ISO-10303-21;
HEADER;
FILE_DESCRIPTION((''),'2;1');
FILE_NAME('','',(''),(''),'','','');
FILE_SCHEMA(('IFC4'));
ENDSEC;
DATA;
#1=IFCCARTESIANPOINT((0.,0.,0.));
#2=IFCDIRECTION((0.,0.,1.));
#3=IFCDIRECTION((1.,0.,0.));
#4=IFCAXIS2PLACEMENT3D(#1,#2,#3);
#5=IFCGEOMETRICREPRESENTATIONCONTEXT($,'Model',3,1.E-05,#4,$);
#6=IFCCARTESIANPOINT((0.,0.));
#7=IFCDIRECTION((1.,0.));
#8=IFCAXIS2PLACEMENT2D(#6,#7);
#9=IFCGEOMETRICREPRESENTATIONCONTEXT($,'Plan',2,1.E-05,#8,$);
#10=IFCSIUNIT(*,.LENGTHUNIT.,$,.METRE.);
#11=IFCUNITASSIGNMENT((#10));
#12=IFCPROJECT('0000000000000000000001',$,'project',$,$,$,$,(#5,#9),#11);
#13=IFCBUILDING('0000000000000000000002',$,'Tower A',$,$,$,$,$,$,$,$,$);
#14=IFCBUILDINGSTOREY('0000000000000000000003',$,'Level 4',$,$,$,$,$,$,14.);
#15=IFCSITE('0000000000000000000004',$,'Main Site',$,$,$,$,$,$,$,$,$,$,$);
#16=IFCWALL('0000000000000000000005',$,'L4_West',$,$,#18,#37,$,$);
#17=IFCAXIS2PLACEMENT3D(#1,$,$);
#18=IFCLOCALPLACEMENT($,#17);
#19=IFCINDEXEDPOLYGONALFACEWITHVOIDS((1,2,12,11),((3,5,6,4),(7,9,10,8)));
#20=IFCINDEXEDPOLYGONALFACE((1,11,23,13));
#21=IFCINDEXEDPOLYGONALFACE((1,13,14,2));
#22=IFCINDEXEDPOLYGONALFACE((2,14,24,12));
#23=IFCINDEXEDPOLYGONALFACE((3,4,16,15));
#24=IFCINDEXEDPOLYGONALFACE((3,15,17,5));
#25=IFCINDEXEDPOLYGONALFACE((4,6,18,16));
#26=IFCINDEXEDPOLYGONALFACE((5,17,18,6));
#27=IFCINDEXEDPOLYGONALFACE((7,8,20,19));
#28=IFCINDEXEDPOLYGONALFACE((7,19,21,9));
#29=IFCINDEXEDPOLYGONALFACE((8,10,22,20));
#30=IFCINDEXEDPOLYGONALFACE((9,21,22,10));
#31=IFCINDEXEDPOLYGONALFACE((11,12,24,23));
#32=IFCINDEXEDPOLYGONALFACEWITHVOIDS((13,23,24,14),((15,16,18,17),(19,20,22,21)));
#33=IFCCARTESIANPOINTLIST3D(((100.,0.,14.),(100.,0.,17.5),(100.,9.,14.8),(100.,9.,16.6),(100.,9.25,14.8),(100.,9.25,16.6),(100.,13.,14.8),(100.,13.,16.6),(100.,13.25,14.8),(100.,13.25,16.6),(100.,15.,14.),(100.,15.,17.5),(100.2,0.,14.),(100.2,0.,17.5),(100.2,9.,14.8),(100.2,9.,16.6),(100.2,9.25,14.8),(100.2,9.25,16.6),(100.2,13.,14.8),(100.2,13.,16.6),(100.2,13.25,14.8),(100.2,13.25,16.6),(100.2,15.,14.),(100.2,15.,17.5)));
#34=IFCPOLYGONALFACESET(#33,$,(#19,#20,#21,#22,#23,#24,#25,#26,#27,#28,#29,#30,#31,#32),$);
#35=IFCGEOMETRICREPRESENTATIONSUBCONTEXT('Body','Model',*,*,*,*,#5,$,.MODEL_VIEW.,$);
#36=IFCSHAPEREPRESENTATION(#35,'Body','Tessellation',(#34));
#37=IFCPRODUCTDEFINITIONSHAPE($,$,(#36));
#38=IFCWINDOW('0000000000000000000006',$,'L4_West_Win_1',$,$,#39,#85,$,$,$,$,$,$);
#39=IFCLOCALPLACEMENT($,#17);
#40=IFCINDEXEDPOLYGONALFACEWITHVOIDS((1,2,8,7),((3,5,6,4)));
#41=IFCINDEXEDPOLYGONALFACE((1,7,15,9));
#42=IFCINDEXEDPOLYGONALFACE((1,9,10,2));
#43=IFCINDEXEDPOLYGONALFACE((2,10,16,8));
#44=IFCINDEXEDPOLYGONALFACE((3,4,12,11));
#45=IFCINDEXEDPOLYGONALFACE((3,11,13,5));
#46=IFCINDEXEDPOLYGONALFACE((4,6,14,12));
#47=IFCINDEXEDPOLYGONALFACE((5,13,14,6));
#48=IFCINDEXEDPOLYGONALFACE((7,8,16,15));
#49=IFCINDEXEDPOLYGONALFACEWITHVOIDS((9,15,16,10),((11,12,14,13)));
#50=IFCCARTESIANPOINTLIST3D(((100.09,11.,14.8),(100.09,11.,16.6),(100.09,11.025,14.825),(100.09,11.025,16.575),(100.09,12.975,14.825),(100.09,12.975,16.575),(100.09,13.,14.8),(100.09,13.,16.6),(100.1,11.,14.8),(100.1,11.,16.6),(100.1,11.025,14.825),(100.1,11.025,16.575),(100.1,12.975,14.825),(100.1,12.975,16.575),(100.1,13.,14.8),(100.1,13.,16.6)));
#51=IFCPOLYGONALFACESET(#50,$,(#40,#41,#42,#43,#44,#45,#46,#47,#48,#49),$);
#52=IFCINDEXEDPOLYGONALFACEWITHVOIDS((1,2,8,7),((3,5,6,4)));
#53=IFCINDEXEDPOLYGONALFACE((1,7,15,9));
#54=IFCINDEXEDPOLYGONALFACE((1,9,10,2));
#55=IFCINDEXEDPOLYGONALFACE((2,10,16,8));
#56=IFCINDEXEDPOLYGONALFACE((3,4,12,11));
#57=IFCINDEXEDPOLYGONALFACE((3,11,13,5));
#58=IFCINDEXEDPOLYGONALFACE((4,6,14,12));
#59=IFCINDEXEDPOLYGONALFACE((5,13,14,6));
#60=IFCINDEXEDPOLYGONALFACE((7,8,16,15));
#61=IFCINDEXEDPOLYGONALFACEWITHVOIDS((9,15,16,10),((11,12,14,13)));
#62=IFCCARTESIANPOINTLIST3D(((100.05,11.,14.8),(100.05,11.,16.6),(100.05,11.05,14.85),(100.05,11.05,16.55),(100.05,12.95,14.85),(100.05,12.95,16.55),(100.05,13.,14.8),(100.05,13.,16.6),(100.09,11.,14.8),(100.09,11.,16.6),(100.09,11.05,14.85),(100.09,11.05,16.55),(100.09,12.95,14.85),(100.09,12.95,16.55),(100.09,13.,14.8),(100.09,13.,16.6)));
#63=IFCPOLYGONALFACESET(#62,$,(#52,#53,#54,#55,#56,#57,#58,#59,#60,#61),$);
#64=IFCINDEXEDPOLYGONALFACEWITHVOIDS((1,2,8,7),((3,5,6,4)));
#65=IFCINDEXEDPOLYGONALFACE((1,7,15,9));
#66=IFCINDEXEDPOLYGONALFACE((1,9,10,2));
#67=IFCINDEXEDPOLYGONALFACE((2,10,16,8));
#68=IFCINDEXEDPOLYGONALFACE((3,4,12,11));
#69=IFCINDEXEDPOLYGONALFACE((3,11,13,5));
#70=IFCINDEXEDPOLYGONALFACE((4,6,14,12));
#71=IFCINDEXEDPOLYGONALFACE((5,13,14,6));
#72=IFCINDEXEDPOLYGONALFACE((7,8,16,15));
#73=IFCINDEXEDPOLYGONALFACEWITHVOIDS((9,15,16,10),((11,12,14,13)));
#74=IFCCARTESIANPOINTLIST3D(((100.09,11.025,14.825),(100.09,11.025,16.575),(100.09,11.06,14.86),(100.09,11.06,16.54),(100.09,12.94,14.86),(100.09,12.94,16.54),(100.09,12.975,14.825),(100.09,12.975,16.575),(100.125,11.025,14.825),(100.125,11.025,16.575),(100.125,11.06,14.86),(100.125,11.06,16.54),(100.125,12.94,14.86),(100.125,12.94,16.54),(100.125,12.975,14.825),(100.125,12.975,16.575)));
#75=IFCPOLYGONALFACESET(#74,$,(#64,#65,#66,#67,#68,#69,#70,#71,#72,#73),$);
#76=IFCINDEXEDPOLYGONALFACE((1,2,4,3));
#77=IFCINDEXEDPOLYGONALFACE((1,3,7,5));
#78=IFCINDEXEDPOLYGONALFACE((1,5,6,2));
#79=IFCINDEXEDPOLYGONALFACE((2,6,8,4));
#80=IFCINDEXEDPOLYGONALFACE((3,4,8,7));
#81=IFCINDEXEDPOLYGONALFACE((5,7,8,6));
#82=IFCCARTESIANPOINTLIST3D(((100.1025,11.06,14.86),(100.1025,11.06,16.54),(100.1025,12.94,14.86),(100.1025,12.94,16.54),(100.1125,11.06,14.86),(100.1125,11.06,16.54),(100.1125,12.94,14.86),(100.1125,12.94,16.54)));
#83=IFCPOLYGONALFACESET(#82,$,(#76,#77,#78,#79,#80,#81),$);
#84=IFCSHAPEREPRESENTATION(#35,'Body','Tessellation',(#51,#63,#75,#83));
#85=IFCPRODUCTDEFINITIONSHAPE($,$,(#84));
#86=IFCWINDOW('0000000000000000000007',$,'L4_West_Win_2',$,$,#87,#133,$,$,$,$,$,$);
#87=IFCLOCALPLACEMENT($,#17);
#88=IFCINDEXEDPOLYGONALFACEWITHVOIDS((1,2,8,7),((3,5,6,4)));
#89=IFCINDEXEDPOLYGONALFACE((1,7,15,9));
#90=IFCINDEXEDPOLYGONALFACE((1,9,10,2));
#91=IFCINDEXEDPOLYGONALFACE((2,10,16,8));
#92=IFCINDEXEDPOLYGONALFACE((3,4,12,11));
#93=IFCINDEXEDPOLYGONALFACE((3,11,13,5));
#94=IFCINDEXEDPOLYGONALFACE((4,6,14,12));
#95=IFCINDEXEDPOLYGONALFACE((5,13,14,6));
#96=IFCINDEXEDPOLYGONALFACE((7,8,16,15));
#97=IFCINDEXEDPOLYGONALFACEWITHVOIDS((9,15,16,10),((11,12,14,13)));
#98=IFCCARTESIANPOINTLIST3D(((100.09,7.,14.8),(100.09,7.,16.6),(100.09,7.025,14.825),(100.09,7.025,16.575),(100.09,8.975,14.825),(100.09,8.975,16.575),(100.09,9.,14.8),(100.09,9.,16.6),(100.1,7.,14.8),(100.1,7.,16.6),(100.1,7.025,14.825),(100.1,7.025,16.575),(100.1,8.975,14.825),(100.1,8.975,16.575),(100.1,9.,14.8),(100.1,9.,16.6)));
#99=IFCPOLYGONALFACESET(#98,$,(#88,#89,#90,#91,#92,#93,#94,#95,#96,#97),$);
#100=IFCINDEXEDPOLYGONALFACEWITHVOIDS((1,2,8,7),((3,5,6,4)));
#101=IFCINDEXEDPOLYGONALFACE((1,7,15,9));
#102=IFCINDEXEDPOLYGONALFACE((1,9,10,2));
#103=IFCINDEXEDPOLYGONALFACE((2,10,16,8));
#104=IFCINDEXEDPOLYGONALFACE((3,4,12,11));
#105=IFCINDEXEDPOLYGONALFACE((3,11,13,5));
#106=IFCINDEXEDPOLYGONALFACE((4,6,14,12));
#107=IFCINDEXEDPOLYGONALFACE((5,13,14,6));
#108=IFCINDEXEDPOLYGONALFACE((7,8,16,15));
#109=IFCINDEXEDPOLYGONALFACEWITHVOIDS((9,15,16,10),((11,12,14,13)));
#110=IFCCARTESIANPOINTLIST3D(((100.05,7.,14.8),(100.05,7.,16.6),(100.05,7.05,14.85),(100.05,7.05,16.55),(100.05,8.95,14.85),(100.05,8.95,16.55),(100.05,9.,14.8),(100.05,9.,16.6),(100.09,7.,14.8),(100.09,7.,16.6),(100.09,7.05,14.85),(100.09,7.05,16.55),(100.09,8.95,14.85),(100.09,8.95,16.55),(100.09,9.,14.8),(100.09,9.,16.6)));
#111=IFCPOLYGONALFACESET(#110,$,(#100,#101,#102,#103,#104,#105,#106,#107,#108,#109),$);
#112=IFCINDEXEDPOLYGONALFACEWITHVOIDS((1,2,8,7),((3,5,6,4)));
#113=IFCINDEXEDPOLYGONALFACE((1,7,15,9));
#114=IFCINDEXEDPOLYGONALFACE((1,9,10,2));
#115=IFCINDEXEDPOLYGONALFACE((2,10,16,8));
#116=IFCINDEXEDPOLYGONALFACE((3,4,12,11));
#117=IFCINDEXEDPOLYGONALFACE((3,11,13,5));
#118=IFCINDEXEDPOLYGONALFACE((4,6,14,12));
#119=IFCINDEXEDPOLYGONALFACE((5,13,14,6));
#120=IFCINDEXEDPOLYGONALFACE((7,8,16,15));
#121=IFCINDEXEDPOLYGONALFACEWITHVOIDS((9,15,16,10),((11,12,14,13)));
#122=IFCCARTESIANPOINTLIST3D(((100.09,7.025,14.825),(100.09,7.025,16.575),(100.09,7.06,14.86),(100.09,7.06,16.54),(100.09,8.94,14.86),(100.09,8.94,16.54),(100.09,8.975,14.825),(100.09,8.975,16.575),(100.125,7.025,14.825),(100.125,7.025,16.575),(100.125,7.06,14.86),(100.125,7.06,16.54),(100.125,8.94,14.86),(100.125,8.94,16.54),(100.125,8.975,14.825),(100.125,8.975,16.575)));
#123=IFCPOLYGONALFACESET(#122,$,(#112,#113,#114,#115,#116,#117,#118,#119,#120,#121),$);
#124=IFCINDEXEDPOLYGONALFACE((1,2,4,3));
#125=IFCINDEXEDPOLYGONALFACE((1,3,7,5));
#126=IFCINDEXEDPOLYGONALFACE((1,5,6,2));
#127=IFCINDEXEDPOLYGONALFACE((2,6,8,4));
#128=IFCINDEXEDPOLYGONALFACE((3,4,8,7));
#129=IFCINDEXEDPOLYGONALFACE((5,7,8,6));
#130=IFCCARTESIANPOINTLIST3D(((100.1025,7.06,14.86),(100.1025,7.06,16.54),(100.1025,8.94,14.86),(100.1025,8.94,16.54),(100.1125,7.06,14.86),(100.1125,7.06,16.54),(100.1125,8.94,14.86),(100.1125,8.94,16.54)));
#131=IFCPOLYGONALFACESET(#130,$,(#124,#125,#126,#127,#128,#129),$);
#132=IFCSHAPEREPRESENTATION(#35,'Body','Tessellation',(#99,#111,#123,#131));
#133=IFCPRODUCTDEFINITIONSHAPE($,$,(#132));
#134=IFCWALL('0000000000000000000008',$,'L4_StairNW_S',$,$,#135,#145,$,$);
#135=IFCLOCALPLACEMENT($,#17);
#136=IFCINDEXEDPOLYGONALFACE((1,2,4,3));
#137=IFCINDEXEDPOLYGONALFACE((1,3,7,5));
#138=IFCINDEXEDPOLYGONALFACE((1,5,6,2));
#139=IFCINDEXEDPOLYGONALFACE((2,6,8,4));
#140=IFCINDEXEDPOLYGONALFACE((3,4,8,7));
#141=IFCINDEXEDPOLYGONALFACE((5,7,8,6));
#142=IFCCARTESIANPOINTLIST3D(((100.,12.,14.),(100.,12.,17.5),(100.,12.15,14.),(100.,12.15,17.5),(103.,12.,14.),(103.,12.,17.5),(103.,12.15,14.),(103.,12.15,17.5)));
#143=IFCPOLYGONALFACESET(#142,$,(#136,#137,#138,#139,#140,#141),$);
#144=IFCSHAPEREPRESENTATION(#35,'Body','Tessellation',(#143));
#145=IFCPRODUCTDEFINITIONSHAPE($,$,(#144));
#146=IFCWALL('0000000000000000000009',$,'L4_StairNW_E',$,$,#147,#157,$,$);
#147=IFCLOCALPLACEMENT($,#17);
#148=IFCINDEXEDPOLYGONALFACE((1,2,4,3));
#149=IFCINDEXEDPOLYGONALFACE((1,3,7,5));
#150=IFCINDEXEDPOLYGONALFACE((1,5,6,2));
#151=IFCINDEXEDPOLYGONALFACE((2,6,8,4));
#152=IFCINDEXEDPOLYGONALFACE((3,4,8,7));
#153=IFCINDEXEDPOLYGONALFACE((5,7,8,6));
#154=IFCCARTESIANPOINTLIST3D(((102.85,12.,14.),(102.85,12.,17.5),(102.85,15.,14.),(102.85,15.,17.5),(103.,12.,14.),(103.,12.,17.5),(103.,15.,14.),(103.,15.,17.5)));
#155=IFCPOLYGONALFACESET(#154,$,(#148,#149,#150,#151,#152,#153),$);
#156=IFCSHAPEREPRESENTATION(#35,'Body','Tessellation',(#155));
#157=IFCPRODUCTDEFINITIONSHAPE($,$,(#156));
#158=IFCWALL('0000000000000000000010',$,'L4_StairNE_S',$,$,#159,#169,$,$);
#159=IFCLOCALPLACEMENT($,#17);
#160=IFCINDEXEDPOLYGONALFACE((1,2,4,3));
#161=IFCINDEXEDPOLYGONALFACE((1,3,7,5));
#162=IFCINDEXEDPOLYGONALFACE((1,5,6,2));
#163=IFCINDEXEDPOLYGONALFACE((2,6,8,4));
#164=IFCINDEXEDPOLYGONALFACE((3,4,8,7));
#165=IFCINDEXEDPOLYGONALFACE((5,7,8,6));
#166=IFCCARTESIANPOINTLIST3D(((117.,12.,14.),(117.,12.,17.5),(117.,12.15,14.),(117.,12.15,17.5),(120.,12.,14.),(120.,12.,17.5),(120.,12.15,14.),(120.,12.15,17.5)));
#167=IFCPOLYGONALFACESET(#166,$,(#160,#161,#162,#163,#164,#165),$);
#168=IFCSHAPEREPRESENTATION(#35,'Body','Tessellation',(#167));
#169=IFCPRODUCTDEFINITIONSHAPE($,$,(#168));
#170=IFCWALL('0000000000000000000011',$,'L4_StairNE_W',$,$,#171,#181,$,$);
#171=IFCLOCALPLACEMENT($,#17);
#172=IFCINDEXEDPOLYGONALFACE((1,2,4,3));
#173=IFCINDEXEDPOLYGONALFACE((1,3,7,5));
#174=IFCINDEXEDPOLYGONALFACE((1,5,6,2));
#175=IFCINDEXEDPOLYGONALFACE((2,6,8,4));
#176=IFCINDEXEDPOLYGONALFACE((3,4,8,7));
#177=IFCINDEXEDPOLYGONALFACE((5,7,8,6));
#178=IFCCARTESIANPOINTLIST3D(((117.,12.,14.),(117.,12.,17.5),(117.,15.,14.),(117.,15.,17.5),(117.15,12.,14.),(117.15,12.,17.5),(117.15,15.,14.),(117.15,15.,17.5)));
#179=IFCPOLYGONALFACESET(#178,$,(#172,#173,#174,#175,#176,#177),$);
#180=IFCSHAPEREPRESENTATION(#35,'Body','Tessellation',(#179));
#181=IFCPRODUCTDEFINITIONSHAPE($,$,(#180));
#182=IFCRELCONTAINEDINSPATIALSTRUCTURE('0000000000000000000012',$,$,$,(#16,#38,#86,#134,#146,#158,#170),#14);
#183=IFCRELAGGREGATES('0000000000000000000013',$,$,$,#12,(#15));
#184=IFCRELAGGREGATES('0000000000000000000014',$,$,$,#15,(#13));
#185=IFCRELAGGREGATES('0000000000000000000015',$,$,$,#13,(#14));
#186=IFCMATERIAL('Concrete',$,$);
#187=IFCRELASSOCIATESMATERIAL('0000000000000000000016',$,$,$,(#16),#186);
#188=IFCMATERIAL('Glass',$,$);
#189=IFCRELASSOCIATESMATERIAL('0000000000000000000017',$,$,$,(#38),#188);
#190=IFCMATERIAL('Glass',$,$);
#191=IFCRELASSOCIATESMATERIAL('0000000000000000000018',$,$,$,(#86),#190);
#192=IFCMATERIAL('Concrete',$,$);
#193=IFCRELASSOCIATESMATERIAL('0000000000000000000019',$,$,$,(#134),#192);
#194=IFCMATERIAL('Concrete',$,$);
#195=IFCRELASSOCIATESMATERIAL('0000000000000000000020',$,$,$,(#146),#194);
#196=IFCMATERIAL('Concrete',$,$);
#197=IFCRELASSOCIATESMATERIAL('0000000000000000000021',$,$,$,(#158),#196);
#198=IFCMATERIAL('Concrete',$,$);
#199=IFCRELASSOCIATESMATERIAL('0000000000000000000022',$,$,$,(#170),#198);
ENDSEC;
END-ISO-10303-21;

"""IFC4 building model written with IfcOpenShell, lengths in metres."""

from ifc_helpers import new_model, si_unit, frame, origin_with_axes, origin_2d_with_axis, place, context, subcontext, project, spatial, line, indexed_curve, outline, extrude, material, element, fill, save


model = new_model("IFC4")

# Units and contexts
model_context = context("Model", 3, precision=1e-05, world=origin_with_axes())
plan_context = context("Plan", 2, precision=1e-05, world=origin_2d_with_axis())
body_context = subcontext(model_context, "Body", "Model", "MODEL_VIEW")
ifc_project = project(units=[si_unit("LENGTHUNIT", "METRE")], contexts=[model_context, plan_context])

# Site, building, storey
site = spatial("IfcSite", under=ifc_project, Name="Main Site")
building = spatial("IfcBuilding", under=site, Name="Tower A")
storey = spatial("IfcBuildingStorey", under=building, Name="Level 4", Elevation=14.0)

# Wall, openings, windows
ifc_material_1 = material(Name="Concrete")
wall_1_placement = place(None, frame((100.0, 15.0, 14.0), z_axis=(0.0, 0.0, 1.0), x_axis=(0.0, -1.0, 0.0)))
wall_1 = element("IfcWall", 1, at=wall_1_placement, inside=storey, material=ifc_material_1, Name="L4_West", context=body_context, shape_type="SweptSolid", body=[
    extrude(outline(indexed_curve([(0.0, 0.0), (0.0, 0.2), (15.0, 0.2), (15.0, 0.0), (0.0, 0.0)], self_intersect=False)), origin_with_axes(), (0.0, 0.0, 1.0), 3.5),
])
opening_1_placement = place(wall_1_placement, frame((2.0, 0.0, 0.8), z_axis=(0.0, 0.0, 1.0), x_axis=(0.0, 1.0, 0.0)))
opening_1 = element("IfcOpeningElement", 2, at=opening_1_placement, cuts=wall_1, context=body_context, shape_type="SweptSolid", body=[
    extrude(outline(indexed_curve([(0.0, 0.0), (0.0, 0.25), (2.0, 0.25), (2.0, 0.0), (0.0, 0.0)], self_intersect=False)), origin_with_axes(), (0.0, 0.0, 1.0), 1.8),
])
opening_2_placement = place(wall_1_placement, frame((6.0, 0.0, 0.8), z_axis=(0.0, 0.0, 1.0), x_axis=(0.0, 1.0, 0.0)))
opening_2 = element("IfcOpeningElement", 3, at=opening_2_placement, cuts=wall_1, context=body_context, shape_type="SweptSolid", body=[
    extrude(outline(indexed_curve([(0.0, 0.0), (0.0, 0.25), (2.0, 0.25), (2.0, 0.0), (0.0, 0.0)], self_intersect=False)), origin_with_axes(), (0.0, 0.0, 1.0), 1.8),
])
ifc_material_2 = material(Name="Glass")
window_1_placement = place(None, frame((100.0, 13.0, 14.8), z_axis=(0.0, 0.0, 1.0), x_axis=(0.0, -1.0, 0.0)))
window_1 = element("IfcWindow", 4, at=window_1_placement, inside=storey, material=ifc_material_2, Name="L4_West_Win_1", context=body_context, shape_type="SweptSolid", body=[
    extrude(outline(indexed_curve([(0.0, 0.0), (2.0, 0.0), (2.0, 1.8), (0.0, 1.8)], segments=[line(1, 2, 3, 4, 1)]), holes=[indexed_curve([(0.025, 0.025), (1.975, 0.025), (1.975, 1.775), (0.025, 1.775)], segments=[line(1, 2, 3, 4, 1)])]), frame((0.0, 0.09, 0.0), z_axis=(0.0, -1.0, 0.0), x_axis=(1.0, 0.0, 0.0)), (0.0, 0.0, -1.0), 0.01),
    extrude(outline(indexed_curve([(0.0, 0.0), (2.0, 0.0), (2.0, 1.8), (0.0, 1.8)], segments=[line(1, 2, 3, 4, 1)]), holes=[indexed_curve([(0.05, 0.05), (1.95, 0.05), (1.95, 1.75), (0.05, 1.75)], segments=[line(1, 2, 3, 4, 1)])]), frame((0.0, 0.05, 0.0), z_axis=(0.0, -1.0, 0.0), x_axis=(1.0, 0.0, 0.0)), (0.0, 0.0, -1.0), 0.04),
    extrude(outline(indexed_curve([(0.0, 0.0), (1.95, 0.0), (1.95, 1.75), (0.0, 1.75)], segments=[line(1, 2, 3, 4, 1)]), holes=[indexed_curve([(0.035, 0.035), (1.915, 0.035), (1.915, 1.715), (0.035, 1.715)], segments=[line(1, 2, 3, 4, 1)])]), frame((0.025, 0.09, 0.025), z_axis=(0.0, -1.0, 0.0), x_axis=(1.0, 0.0, 0.0)), (0.0, 0.0, -1.0), 0.035),
    extrude(outline(indexed_curve([(0.035, 0.035), (1.915, 0.035), (1.915, 1.715), (0.035, 1.715)], segments=[line(1, 2, 3, 4, 1)])), frame((0.025, 0.1025, 0.025), z_axis=(0.0, -1.0, 0.0), x_axis=(1.0, 0.0, 0.0)), (0.0, 0.0, -1.0), 0.01),
])
fill(opening_1, window_1)
ifc_material_3 = material(Name="Glass")
window_2_placement = place(None, frame((100.0, 9.0, 14.8), z_axis=(0.0, 0.0, 1.0), x_axis=(0.0, -1.0, 0.0)))
window_2 = element("IfcWindow", 5, at=window_2_placement, inside=storey, material=ifc_material_3, Name="L4_West_Win_2", context=body_context, shape_type="SweptSolid", body=[
    extrude(outline(indexed_curve([(0.0, 0.0), (2.0, 0.0), (2.0, 1.8), (0.0, 1.8)], segments=[line(1, 2, 3, 4, 1)]), holes=[indexed_curve([(0.025, 0.025), (1.975, 0.025), (1.975, 1.775), (0.025, 1.775)], segments=[line(1, 2, 3, 4, 1)])]), frame((0.0, 0.09, 0.0), z_axis=(0.0, -1.0, 0.0), x_axis=(1.0, 0.0, 0.0)), (0.0, 0.0, -1.0), 0.01),
    extrude(outline(indexed_curve([(0.0, 0.0), (2.0, 0.0), (2.0, 1.8), (0.0, 1.8)], segments=[line(1, 2, 3, 4, 1)]), holes=[indexed_curve([(0.05, 0.05), (1.95, 0.05), (1.95, 1.75), (0.05, 1.75)], segments=[line(1, 2, 3, 4, 1)])]), frame((0.0, 0.05, 0.0), z_axis=(0.0, -1.0, 0.0), x_axis=(1.0, 0.0, 0.0)), (0.0, 0.0, -1.0), 0.04),
    extrude(outline(indexed_curve([(0.0, 0.0), (1.95, 0.0), (1.95, 1.75), (0.0, 1.75)], segments=[line(1, 2, 3, 4, 1)]), holes=[indexed_curve([(0.035, 0.035), (1.915, 0.035), (1.915, 1.715), (0.035, 1.715)], segments=[line(1, 2, 3, 4, 1)])]), frame((0.025, 0.09, 0.025), z_axis=(0.0, -1.0, 0.0), x_axis=(1.0, 0.0, 0.0)), (0.0, 0.0, -1.0), 0.035),
    extrude(outline(indexed_curve([(0.035, 0.035), (1.915, 0.035), (1.915, 1.715), (0.035, 1.715)], segments=[line(1, 2, 3, 4, 1)])), frame((0.025, 0.1025, 0.025), z_axis=(0.0, -1.0, 0.0), x_axis=(1.0, 0.0, 0.0)), (0.0, 0.0, -1.0), 0.01),
])
fill(opening_2, window_2)

# Walls
ifc_material_4 = material(Name="Concrete")
wall_2_placement = place(None, frame((100.0, 12.0, 14.0), z_axis=(0.0, 0.0, 1.0), x_axis=(1.0, 0.0, 0.0)))
element("IfcWall", 6, at=wall_2_placement, inside=storey, material=ifc_material_4, Name="L4_StairNW_S", context=body_context, shape_type="SweptSolid", body=[
    extrude(outline(indexed_curve([(0.0, 0.0), (0.0, 0.15), (3.0, 0.15), (3.0, 0.0), (0.0, 0.0)], self_intersect=False)), origin_with_axes(), (0.0, 0.0, 1.0), 3.5),
])
ifc_material_5 = material(Name="Concrete")
wall_3_placement = place(None, frame((103.0, 12.0, 14.0), z_axis=(0.0, 0.0, 1.0), x_axis=(0.0, 1.0, 0.0)))
element("IfcWall", 7, at=wall_3_placement, inside=storey, material=ifc_material_5, Name="L4_StairNW_E", context=body_context, shape_type="SweptSolid", body=[
    extrude(outline(indexed_curve([(0.0, 0.0), (0.0, 0.15), (3.0, 0.15), (3.0, 0.0), (0.0, 0.0)], self_intersect=False)), origin_with_axes(), (0.0, 0.0, 1.0), 3.5),
])
ifc_material_6 = material(Name="Concrete")
wall_4_placement = place(None, frame((117.0, 12.0, 14.0), z_axis=(0.0, 0.0, 1.0), x_axis=(1.0, 0.0, 0.0)))
element("IfcWall", 8, at=wall_4_placement, inside=storey, material=ifc_material_6, Name="L4_StairNE_S", context=body_context, shape_type="SweptSolid", body=[
    extrude(outline(indexed_curve([(0.0, 0.0), (0.0, 0.15), (3.0, 0.15), (3.0, 0.0), (0.0, 0.0)], self_intersect=False)), origin_with_axes(), (0.0, 0.0, 1.0), 3.5),
])
ifc_material_7 = material(Name="Concrete")
wall_5_placement = place(None, frame((117.0, 15.0, 14.0), z_axis=(0.0, 0.0, 1.0), x_axis=(0.0, -1.0, 0.0)))
element("IfcWall", 9, at=wall_5_placement, inside=storey, material=ifc_material_7, Name="L4_StairNE_W", context=body_context, shape_type="SweptSolid", body=[
    extrude(outline(indexed_curve([(0.0, 0.0), (0.0, 0.15), (3.0, 0.15), (3.0, 0.0), (0.0, 0.0)], self_intersect=False)), origin_with_axes(), (0.0, 0.0, 1.0), 3.5),
])

save(model, "model.ifc")
